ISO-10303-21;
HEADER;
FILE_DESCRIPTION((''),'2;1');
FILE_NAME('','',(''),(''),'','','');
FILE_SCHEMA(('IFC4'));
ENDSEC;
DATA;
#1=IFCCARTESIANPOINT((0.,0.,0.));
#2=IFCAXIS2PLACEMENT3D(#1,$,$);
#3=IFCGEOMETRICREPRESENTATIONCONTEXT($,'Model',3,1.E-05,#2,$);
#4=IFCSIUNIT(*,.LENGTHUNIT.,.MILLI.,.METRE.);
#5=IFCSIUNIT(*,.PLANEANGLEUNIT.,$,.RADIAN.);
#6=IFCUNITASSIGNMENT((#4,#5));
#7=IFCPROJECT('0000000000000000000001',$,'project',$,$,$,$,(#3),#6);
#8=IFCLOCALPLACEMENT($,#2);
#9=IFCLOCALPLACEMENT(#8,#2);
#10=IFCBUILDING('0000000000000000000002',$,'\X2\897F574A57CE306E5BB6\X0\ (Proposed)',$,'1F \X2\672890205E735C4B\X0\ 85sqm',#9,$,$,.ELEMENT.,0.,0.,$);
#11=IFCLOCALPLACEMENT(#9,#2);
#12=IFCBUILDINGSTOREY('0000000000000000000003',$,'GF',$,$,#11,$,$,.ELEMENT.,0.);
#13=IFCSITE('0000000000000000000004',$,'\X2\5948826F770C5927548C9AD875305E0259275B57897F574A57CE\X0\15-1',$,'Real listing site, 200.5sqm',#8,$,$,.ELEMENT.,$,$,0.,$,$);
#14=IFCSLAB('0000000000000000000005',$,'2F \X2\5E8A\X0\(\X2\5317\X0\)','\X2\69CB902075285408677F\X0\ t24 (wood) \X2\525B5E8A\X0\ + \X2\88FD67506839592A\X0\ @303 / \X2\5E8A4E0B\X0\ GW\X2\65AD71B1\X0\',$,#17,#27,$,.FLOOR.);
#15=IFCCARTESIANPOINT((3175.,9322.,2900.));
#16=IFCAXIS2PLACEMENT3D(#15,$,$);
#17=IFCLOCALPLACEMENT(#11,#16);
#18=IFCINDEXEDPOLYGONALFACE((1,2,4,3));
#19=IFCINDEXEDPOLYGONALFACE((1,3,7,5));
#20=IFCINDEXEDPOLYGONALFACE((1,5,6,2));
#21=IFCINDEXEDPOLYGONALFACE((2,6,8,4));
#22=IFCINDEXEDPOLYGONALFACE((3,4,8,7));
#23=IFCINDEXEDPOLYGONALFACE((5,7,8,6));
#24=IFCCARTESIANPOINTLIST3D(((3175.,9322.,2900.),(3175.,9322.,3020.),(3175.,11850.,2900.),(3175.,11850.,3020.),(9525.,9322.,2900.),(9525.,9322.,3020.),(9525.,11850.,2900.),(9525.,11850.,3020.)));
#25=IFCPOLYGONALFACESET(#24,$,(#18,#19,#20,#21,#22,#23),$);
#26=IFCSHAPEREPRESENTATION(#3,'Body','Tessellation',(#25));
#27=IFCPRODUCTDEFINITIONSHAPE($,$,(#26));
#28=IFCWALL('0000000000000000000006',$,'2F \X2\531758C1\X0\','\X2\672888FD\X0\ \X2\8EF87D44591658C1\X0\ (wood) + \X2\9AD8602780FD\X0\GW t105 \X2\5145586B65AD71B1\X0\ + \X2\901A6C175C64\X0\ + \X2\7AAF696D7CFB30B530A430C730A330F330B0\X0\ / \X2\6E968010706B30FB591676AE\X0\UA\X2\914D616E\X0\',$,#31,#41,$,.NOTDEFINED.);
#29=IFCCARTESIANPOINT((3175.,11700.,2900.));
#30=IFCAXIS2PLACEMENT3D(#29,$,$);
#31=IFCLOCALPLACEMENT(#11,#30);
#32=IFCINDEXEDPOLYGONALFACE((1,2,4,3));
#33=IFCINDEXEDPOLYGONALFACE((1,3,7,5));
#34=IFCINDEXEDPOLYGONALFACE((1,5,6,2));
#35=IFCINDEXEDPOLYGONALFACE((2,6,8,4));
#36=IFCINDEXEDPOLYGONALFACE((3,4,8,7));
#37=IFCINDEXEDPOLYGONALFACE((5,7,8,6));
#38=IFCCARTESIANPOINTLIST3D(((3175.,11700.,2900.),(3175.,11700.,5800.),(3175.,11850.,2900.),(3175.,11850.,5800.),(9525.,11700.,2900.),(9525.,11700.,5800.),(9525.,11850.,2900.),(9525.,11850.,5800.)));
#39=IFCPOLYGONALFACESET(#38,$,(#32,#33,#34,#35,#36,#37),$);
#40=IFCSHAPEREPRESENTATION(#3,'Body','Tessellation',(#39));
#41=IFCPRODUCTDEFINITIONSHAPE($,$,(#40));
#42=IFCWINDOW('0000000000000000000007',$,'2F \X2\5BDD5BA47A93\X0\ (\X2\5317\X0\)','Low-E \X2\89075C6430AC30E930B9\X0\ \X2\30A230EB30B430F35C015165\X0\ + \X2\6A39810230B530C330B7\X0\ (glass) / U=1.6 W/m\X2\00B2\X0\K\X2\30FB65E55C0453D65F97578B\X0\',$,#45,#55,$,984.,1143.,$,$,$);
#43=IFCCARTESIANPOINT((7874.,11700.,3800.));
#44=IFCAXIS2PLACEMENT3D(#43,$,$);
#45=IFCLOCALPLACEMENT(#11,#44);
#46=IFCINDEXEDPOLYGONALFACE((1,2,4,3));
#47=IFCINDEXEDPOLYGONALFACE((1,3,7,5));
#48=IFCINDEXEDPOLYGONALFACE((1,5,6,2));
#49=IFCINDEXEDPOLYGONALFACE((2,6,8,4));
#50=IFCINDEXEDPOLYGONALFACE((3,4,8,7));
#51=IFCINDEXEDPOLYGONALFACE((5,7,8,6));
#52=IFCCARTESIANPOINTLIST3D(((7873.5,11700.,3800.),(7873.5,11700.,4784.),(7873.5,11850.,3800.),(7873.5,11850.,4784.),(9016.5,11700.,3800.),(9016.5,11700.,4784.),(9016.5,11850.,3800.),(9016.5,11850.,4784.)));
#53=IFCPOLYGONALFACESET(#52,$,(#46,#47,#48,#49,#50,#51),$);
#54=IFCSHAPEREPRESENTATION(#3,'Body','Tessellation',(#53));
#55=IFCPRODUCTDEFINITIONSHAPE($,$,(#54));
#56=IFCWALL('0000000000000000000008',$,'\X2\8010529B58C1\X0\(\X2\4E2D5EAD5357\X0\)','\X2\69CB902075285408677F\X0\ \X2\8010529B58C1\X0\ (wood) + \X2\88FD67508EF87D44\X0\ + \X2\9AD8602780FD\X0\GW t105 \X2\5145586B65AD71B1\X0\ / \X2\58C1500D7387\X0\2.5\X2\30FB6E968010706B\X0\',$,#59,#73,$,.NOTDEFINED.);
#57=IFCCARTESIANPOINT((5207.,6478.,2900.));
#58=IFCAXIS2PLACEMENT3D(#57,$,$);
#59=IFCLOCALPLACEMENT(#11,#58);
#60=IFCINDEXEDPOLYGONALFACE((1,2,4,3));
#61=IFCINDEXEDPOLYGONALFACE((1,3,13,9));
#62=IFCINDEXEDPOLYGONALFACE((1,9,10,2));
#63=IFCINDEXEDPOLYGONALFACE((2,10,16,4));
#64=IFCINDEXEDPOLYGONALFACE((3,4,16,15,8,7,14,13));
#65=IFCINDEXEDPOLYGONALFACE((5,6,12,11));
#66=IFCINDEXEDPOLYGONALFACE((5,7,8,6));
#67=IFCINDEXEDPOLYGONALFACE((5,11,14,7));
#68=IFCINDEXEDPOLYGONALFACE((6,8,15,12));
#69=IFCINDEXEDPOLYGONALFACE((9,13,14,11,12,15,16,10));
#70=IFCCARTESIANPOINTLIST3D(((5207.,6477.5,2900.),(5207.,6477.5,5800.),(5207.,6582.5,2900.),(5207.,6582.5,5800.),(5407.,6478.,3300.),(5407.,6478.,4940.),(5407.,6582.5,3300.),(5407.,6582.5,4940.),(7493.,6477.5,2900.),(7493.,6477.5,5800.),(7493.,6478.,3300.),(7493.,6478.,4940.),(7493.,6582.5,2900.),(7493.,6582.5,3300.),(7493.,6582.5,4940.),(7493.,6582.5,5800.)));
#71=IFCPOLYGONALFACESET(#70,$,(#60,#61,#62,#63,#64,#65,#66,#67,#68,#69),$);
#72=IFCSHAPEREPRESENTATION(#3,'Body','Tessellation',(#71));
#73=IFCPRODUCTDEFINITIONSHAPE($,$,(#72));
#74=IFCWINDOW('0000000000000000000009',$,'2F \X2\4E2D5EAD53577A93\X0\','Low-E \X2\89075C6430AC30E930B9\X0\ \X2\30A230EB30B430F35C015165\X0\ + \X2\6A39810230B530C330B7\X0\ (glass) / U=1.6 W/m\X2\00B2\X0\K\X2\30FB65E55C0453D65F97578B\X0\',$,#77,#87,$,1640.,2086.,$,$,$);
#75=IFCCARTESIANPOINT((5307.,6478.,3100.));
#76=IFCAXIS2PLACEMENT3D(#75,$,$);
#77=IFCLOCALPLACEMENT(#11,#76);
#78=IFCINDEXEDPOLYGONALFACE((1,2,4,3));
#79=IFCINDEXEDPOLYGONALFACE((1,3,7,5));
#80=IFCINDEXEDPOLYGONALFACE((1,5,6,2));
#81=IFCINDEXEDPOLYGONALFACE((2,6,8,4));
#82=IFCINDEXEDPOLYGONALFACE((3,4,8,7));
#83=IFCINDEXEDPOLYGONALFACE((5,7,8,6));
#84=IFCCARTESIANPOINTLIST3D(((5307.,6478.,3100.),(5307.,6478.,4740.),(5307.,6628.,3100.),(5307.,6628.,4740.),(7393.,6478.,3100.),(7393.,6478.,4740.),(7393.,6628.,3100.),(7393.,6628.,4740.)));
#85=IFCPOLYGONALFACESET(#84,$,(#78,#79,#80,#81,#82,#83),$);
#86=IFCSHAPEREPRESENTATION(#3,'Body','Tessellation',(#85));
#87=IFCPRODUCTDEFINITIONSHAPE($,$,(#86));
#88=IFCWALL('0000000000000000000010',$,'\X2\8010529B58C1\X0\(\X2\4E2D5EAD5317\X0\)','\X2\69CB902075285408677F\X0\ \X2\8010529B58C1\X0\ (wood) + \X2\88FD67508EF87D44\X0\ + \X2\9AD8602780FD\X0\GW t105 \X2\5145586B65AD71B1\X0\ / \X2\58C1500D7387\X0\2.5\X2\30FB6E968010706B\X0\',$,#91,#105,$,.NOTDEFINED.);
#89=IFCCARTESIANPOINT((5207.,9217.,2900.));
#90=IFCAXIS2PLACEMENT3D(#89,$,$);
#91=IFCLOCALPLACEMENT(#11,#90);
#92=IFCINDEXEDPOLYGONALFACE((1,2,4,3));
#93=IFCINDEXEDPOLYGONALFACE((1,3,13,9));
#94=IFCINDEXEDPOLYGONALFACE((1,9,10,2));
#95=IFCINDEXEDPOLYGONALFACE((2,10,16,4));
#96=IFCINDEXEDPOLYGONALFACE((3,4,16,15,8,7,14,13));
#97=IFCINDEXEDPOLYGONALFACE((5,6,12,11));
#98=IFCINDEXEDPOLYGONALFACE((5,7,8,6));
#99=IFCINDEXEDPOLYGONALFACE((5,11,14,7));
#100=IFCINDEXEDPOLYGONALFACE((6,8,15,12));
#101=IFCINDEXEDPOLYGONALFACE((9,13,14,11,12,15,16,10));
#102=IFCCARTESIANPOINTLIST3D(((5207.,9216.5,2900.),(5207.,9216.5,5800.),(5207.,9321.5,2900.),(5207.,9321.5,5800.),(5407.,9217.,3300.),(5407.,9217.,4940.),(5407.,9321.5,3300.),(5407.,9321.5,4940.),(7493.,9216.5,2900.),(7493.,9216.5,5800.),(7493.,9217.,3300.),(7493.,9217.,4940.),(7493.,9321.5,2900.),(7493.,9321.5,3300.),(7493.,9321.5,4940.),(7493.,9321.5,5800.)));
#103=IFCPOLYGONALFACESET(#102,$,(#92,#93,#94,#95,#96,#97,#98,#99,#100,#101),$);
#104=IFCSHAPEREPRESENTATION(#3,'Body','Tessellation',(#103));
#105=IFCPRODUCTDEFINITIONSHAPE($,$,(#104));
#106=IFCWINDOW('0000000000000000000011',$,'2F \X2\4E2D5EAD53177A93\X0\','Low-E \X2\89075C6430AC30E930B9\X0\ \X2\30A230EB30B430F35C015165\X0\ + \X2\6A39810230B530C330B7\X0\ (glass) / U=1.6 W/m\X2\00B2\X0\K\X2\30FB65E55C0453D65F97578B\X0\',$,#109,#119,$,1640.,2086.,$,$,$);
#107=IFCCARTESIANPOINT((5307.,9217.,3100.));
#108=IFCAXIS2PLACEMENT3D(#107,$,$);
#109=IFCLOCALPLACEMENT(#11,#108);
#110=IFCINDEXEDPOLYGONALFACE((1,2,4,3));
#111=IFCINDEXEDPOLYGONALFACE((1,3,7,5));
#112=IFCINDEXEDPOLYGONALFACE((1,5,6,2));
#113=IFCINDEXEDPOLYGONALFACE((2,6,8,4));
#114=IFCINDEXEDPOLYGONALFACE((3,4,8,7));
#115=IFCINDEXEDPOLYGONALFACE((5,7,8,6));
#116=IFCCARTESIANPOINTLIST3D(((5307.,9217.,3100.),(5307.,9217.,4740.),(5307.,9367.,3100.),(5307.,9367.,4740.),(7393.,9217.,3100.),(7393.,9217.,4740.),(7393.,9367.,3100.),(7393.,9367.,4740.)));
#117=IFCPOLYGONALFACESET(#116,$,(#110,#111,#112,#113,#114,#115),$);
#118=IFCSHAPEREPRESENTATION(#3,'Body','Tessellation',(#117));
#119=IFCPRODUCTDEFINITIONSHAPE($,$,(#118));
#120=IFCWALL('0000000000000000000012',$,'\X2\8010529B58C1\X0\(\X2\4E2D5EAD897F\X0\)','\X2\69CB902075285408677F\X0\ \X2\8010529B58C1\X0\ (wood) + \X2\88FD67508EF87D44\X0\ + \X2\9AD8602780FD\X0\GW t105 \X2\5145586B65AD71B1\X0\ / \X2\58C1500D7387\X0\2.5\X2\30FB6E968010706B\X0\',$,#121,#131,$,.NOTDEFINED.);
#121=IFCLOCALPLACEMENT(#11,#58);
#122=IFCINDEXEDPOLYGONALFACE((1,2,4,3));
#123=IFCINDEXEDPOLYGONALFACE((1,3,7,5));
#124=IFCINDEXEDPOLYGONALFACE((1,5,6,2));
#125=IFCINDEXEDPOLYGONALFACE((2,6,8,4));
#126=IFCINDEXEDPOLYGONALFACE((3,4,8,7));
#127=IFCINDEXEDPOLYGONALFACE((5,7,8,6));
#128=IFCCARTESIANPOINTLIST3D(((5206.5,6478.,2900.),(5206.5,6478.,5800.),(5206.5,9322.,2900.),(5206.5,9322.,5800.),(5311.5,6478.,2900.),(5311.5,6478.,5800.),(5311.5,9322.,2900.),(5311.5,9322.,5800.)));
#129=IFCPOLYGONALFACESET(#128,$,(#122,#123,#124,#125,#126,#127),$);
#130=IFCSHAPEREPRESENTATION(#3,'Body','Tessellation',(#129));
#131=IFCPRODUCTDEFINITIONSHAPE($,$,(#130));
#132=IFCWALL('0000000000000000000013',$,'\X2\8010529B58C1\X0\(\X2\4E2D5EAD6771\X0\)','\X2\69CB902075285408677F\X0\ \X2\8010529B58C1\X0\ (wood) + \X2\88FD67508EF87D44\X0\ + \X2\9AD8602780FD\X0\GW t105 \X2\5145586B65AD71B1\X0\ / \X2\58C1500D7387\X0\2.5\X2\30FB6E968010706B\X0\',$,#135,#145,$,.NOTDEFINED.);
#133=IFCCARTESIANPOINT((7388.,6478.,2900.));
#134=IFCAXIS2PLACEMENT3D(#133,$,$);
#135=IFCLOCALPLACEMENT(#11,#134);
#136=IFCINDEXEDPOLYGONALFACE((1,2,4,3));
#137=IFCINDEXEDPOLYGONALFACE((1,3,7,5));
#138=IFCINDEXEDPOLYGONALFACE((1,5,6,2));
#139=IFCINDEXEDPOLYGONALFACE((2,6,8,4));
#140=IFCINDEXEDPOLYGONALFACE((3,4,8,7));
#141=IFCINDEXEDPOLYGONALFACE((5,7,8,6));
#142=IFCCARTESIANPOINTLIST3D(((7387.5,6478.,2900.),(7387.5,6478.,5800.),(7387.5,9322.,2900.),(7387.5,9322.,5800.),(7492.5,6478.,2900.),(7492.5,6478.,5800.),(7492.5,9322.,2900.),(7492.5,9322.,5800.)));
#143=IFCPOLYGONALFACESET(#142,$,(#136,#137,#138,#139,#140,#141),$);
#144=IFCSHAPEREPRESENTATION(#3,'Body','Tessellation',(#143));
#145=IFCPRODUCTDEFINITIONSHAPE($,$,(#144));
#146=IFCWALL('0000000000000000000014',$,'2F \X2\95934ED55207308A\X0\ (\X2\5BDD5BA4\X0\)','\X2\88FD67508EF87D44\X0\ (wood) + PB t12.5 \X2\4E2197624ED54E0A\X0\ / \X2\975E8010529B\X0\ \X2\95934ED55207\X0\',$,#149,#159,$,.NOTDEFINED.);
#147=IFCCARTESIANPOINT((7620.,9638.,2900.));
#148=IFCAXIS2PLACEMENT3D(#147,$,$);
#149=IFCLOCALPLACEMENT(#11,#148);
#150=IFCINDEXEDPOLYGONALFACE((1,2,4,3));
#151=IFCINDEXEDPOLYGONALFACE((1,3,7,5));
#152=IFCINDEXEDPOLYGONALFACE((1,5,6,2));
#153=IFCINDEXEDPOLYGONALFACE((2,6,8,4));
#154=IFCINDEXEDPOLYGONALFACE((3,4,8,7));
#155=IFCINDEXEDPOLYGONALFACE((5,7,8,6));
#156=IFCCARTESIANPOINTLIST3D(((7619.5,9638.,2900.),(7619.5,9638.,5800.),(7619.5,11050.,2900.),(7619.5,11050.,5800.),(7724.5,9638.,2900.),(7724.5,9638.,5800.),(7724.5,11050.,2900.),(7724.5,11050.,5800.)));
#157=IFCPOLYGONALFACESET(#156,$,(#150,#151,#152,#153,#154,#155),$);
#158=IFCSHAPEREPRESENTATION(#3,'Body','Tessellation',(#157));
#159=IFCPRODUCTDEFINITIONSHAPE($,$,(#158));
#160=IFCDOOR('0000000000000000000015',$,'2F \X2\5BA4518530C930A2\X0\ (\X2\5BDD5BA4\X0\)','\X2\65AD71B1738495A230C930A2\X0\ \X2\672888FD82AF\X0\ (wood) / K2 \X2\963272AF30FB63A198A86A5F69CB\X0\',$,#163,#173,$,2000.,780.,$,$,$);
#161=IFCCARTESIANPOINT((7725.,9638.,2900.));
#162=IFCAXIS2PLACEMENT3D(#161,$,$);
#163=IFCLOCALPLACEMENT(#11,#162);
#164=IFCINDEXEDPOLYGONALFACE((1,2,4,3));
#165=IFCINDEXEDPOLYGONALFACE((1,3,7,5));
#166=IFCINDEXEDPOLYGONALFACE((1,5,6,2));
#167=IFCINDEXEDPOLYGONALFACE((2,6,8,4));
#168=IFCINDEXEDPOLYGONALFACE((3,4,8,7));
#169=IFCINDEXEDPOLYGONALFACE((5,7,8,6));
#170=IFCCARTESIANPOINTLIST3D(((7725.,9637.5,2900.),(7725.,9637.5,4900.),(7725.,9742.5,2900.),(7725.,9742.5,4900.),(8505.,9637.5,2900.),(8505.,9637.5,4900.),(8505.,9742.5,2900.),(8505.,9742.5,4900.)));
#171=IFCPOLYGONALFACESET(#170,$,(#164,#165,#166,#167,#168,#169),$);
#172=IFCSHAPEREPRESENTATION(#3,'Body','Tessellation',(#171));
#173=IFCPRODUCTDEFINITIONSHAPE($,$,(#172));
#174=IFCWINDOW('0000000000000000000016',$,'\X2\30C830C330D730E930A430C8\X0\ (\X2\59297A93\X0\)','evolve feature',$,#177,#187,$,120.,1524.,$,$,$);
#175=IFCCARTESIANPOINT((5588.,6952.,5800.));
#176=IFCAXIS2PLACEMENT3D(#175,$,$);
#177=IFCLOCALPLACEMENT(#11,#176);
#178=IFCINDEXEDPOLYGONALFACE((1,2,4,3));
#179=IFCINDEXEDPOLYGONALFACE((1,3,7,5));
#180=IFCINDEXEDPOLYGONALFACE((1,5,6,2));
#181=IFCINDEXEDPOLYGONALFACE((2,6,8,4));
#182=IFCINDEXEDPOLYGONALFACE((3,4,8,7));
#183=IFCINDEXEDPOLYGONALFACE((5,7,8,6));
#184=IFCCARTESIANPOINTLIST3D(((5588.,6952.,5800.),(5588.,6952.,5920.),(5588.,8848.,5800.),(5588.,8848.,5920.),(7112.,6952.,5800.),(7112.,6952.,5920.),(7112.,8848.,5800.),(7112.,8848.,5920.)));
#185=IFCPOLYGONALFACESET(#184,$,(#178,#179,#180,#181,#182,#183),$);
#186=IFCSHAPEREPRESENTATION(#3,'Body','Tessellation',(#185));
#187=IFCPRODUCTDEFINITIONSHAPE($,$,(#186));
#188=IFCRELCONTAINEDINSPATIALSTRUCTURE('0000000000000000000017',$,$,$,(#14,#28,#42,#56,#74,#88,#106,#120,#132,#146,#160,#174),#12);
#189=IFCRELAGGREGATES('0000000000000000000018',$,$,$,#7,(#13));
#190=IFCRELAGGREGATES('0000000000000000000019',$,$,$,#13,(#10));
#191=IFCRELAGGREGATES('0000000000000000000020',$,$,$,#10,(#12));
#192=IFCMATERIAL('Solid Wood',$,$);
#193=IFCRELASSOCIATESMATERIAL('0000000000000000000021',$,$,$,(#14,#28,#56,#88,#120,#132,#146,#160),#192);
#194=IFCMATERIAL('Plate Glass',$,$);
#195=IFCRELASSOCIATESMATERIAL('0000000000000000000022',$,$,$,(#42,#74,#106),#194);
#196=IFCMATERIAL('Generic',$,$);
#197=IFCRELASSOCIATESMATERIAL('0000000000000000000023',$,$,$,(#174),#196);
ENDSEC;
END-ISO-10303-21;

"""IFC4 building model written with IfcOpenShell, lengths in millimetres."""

from ifc_helpers import new_model, si_unit, frame, frame_2d, origin, place, context, project, spatial, rectangle, extrude, material, element, fill, save


model = new_model("IFC4")

# Units and contexts
model_context = context("Model", 3, precision=1e-05, world=origin())
ifc_project = project(units=[si_unit("LENGTHUNIT", "METRE", prefix="MILLI"), si_unit("PLANEANGLEUNIT", "RADIAN")], contexts=[model_context])

# Site, building, storey
site_placement = place(None, origin())
site = spatial("IfcSite", under=ifc_project, at=site_placement, Name="奈良県大和高田市大字西坊城15-1", ObjectType="Real listing site, 200.5sqm", CompositionType="ELEMENT", RefElevation=0.0)
building_placement = place(site_placement, origin())
building = spatial("IfcBuilding", under=site, at=building_placement, Name="西坊城の家 (Proposed)", ObjectType="1F 木造平屋 85sqm", CompositionType="ELEMENT", ElevationOfRefHeight=0.0, ElevationOfTerrain=0.0)
storey_placement = place(building_placement, origin())
storey = spatial("IfcBuildingStorey", under=building, at=storey_placement, Name="GF", CompositionType="ELEMENT", Elevation=0.0)

# Slab
ifc_material_1 = material(Name="Solid Wood")
slab_placement = place(storey_placement, frame((3175.0, 9322.0, 2900.0)))
element("IfcSlab", 1, at=slab_placement, inside=storey, material=ifc_material_1, Name="2F 床(北)", Description="構造用合板 t24 (wood) 剛床 + 製材根太 @303 / 床下 GW断熱", PredefinedType="FLOOR", context=model_context, shape_type="SweptSolid", body=[
    extrude(rectangle(XDim=6350.0, YDim=2528.0, at=frame_2d((3175.0, 1264.0))), frame((3175.0, 9322.0, 2900.0)), (0.0, 0.0, 1.0), 120.0),
])

# Walls, openings, windows
wall_1_placement = place(storey_placement, frame((3175.0, 11700.0, 2900.0)))
wall_1 = element("IfcWall", 2, at=wall_1_placement, inside=storey, material=ifc_material_1, Name="2F 北壁", Description="木製 軸組外壁 (wood) + 高性能GW t105 充填断熱 + 通気層 + 窯業系サイディング / 準耐火・外皮UA配慮", PredefinedType="NOTDEFINED", context=model_context, shape_type="SweptSolid", body=[
    extrude(rectangle(XDim=6350.0, YDim=150.0, at=frame_2d((3175.0, 75.0))), frame((3175.0, 11700.0, 2900.0)), (0.0, 0.0, 1.0), 2900.0),
])
opening_1_placement = place(storey_placement, frame((7874.0, 11700.0, 3800.0)))
opening_1 = element("IfcOpeningElement", 3, at=opening_1_placement, cuts=wall_1, PredefinedType="NOTDEFINED", context=model_context, shape_type="SweptSolid", body=[
    extrude(rectangle(XDim=1143.0, YDim=150.0, at=frame_2d((571.0, 75.0))), frame((7874.0, 11700.0, 3800.0)), (0.0, 0.0, 1.0), 984.0),
])
ifc_material_2 = material(Name="Plate Glass")
window_1_placement = place(storey_placement, frame((7874.0, 11700.0, 3800.0)))
window_1 = element("IfcWindow", 4, at=window_1_placement, inside=storey, material=ifc_material_2, Name="2F 寝室窓 (北)", Description="Low-E 複層ガラス アルゴン封入 + 樹脂サッシ (glass) / U=1.6 W/m²K・日射取得型", OverallHeight=984.0, OverallWidth=1143.0, context=model_context, shape_type="SweptSolid", body=[
    extrude(rectangle(XDim=1143.0, YDim=150.0, at=frame_2d((571.0, 75.0))), frame((7874.0, 11700.0, 3800.0)), (0.0, 0.0, 1.0), 984.0),
])
fill(opening_1, window_1)
wall_2_placement = place(storey_placement, frame((5207.0, 6478.0, 2900.0)))
wall_2 = element("IfcWall", 5, at=wall_2_placement, inside=storey, material=ifc_material_1, Name="耐力壁(中庭南)", Description="構造用合板 耐力壁 (wood) + 製材軸組 + 高性能GW t105 充填断熱 / 壁倍率2.5・準耐火", PredefinedType="NOTDEFINED", context=model_context, shape_type="SweptSolid", body=[
    extrude(rectangle(XDim=2286.0, YDim=105.0, at=frame_2d((1143.0, 52.0))), frame((5207.0, 6478.0, 2900.0)), (0.0, 0.0, 1.0), 2900.0),
])
opening_2_placement = place(storey_placement, frame((5307.0, 6478.0, 3100.0)))
opening_2 = element("IfcOpeningElement", 6, at=opening_2_placement, cuts=wall_2, PredefinedType="NOTDEFINED", context=model_context, shape_type="SweptSolid", body=[
    extrude(rectangle(XDim=2086.0, YDim=150.0, at=frame_2d((1043.0, 75.0))), frame((5307.0, 6478.0, 3100.0)), (0.0, 0.0, 1.0), 1640.0),
])
window_2_placement = place(storey_placement, frame((5307.0, 6478.0, 3100.0)))
window_2 = element("IfcWindow", 7, at=window_2_placement, inside=storey, material=ifc_material_2, Name="2F 中庭南窓", Description="Low-E 複層ガラス アルゴン封入 + 樹脂サッシ (glass) / U=1.6 W/m²K・日射取得型", OverallHeight=1640.0, OverallWidth=2086.0, context=model_context, shape_type="SweptSolid", body=[
    extrude(rectangle(XDim=2086.0, YDim=150.0, at=frame_2d((1043.0, 75.0))), frame((5307.0, 6478.0, 3100.0)), (0.0, 0.0, 1.0), 1640.0),
])
fill(opening_2, window_2)
wall_3_placement = place(storey_placement, frame((5207.0, 9217.0, 2900.0)))
wall_3 = element("IfcWall", 8, at=wall_3_placement, inside=storey, material=ifc_material_1, Name="耐力壁(中庭北)", Description="構造用合板 耐力壁 (wood) + 製材軸組 + 高性能GW t105 充填断熱 / 壁倍率2.5・準耐火", PredefinedType="NOTDEFINED", context=model_context, shape_type="SweptSolid", body=[
    extrude(rectangle(XDim=2286.0, YDim=105.0, at=frame_2d((1143.0, 52.0))), frame((5207.0, 9217.0, 2900.0)), (0.0, 0.0, 1.0), 2900.0),
])
opening_3_placement = place(storey_placement, frame((5307.0, 9217.0, 3100.0)))
opening_3 = element("IfcOpeningElement", 9, at=opening_3_placement, cuts=wall_3, PredefinedType="NOTDEFINED", context=model_context, shape_type="SweptSolid", body=[
    extrude(rectangle(XDim=2086.0, YDim=150.0, at=frame_2d((1043.0, 75.0))), frame((5307.0, 9217.0, 3100.0)), (0.0, 0.0, 1.0), 1640.0),
])
window_3_placement = place(storey_placement, frame((5307.0, 9217.0, 3100.0)))
window_3 = element("IfcWindow", 10, at=window_3_placement, inside=storey, material=ifc_material_2, Name="2F 中庭北窓", Description="Low-E 複層ガラス アルゴン封入 + 樹脂サッシ (glass) / U=1.6 W/m²K・日射取得型", OverallHeight=1640.0, OverallWidth=2086.0, context=model_context, shape_type="SweptSolid", body=[
    extrude(rectangle(XDim=2086.0, YDim=150.0, at=frame_2d((1043.0, 75.0))), frame((5307.0, 9217.0, 3100.0)), (0.0, 0.0, 1.0), 1640.0),
])
fill(opening_3, window_3)

# Walls
wall_4_placement = place(storey_placement, frame((5207.0, 6478.0, 2900.0)))
element("IfcWall", 11, at=wall_4_placement, inside=storey, material=ifc_material_1, Name="耐力壁(中庭西)", Description="構造用合板 耐力壁 (wood) + 製材軸組 + 高性能GW t105 充填断熱 / 壁倍率2.5・準耐火", PredefinedType="NOTDEFINED", context=model_context, shape_type="SweptSolid", body=[
    extrude(rectangle(XDim=105.0, YDim=2844.0, at=frame_2d((52.0, 1422.0))), frame((5207.0, 6478.0, 2900.0)), (0.0, 0.0, 1.0), 2900.0),
])
wall_5_placement = place(storey_placement, frame((7388.0, 6478.0, 2900.0)))
element("IfcWall", 12, at=wall_5_placement, inside=storey, material=ifc_material_1, Name="耐力壁(中庭東)", Description="構造用合板 耐力壁 (wood) + 製材軸組 + 高性能GW t105 充填断熱 / 壁倍率2.5・準耐火", PredefinedType="NOTDEFINED", context=model_context, shape_type="SweptSolid", body=[
    extrude(rectangle(XDim=105.0, YDim=2844.0, at=frame_2d((52.0, 1422.0))), frame((7388.0, 6478.0, 2900.0)), (0.0, 0.0, 1.0), 2900.0),
])
wall_6_placement = place(storey_placement, frame((7620.0, 9638.0, 2900.0)))
element("IfcWall", 13, at=wall_6_placement, inside=storey, material=ifc_material_1, Name="2F 間仕切り (寝室)", Description="製材軸組 (wood) + PB t12.5 両面仕上 / 非耐力 間仕切", PredefinedType="NOTDEFINED", context=model_context, shape_type="SweptSolid", body=[
    extrude(rectangle(XDim=105.0, YDim=1412.0, at=frame_2d((52.0, 706.0))), frame((7620.0, 9638.0, 2900.0)), (0.0, 0.0, 1.0), 2900.0),
])

# Door
door_placement = place(storey_placement, frame((7725.0, 9638.0, 2900.0)))
element("IfcDoor", 14, at=door_placement, inside=storey, material=ifc_material_1, Name="2F 室内ドア (寝室)", Description="断熱玄関ドア 木製芯 (wood) / K2 防犯・採風機構", OverallHeight=2000.0, OverallWidth=780.0, context=model_context, shape_type="SweptSolid", body=[
    extrude(rectangle(XDim=780.0, YDim=105.0, at=frame_2d((390.0, 52.0))), frame((7725.0, 9638.0, 2900.0)), (0.0, 0.0, 1.0), 2000.0),
])

# Window
ifc_material_3 = material(Name="Generic")
window_4_placement = place(storey_placement, frame((5588.0, 6952.0, 5800.0)))
element("IfcWindow", 15, at=window_4_placement, inside=storey, material=ifc_material_3, Name="トップライト (天窓)", Description="evolve feature", OverallHeight=120.0, OverallWidth=1524.0, context=model_context, shape_type="SweptSolid", body=[
    extrude(rectangle(XDim=1524.0, YDim=1896.0, at=frame_2d((762.0, 948.0))), frame((5588.0, 6952.0, 5800.0)), (0.0, 0.0, 1.0), 120.0),
])

save(model, "model.ifc")
